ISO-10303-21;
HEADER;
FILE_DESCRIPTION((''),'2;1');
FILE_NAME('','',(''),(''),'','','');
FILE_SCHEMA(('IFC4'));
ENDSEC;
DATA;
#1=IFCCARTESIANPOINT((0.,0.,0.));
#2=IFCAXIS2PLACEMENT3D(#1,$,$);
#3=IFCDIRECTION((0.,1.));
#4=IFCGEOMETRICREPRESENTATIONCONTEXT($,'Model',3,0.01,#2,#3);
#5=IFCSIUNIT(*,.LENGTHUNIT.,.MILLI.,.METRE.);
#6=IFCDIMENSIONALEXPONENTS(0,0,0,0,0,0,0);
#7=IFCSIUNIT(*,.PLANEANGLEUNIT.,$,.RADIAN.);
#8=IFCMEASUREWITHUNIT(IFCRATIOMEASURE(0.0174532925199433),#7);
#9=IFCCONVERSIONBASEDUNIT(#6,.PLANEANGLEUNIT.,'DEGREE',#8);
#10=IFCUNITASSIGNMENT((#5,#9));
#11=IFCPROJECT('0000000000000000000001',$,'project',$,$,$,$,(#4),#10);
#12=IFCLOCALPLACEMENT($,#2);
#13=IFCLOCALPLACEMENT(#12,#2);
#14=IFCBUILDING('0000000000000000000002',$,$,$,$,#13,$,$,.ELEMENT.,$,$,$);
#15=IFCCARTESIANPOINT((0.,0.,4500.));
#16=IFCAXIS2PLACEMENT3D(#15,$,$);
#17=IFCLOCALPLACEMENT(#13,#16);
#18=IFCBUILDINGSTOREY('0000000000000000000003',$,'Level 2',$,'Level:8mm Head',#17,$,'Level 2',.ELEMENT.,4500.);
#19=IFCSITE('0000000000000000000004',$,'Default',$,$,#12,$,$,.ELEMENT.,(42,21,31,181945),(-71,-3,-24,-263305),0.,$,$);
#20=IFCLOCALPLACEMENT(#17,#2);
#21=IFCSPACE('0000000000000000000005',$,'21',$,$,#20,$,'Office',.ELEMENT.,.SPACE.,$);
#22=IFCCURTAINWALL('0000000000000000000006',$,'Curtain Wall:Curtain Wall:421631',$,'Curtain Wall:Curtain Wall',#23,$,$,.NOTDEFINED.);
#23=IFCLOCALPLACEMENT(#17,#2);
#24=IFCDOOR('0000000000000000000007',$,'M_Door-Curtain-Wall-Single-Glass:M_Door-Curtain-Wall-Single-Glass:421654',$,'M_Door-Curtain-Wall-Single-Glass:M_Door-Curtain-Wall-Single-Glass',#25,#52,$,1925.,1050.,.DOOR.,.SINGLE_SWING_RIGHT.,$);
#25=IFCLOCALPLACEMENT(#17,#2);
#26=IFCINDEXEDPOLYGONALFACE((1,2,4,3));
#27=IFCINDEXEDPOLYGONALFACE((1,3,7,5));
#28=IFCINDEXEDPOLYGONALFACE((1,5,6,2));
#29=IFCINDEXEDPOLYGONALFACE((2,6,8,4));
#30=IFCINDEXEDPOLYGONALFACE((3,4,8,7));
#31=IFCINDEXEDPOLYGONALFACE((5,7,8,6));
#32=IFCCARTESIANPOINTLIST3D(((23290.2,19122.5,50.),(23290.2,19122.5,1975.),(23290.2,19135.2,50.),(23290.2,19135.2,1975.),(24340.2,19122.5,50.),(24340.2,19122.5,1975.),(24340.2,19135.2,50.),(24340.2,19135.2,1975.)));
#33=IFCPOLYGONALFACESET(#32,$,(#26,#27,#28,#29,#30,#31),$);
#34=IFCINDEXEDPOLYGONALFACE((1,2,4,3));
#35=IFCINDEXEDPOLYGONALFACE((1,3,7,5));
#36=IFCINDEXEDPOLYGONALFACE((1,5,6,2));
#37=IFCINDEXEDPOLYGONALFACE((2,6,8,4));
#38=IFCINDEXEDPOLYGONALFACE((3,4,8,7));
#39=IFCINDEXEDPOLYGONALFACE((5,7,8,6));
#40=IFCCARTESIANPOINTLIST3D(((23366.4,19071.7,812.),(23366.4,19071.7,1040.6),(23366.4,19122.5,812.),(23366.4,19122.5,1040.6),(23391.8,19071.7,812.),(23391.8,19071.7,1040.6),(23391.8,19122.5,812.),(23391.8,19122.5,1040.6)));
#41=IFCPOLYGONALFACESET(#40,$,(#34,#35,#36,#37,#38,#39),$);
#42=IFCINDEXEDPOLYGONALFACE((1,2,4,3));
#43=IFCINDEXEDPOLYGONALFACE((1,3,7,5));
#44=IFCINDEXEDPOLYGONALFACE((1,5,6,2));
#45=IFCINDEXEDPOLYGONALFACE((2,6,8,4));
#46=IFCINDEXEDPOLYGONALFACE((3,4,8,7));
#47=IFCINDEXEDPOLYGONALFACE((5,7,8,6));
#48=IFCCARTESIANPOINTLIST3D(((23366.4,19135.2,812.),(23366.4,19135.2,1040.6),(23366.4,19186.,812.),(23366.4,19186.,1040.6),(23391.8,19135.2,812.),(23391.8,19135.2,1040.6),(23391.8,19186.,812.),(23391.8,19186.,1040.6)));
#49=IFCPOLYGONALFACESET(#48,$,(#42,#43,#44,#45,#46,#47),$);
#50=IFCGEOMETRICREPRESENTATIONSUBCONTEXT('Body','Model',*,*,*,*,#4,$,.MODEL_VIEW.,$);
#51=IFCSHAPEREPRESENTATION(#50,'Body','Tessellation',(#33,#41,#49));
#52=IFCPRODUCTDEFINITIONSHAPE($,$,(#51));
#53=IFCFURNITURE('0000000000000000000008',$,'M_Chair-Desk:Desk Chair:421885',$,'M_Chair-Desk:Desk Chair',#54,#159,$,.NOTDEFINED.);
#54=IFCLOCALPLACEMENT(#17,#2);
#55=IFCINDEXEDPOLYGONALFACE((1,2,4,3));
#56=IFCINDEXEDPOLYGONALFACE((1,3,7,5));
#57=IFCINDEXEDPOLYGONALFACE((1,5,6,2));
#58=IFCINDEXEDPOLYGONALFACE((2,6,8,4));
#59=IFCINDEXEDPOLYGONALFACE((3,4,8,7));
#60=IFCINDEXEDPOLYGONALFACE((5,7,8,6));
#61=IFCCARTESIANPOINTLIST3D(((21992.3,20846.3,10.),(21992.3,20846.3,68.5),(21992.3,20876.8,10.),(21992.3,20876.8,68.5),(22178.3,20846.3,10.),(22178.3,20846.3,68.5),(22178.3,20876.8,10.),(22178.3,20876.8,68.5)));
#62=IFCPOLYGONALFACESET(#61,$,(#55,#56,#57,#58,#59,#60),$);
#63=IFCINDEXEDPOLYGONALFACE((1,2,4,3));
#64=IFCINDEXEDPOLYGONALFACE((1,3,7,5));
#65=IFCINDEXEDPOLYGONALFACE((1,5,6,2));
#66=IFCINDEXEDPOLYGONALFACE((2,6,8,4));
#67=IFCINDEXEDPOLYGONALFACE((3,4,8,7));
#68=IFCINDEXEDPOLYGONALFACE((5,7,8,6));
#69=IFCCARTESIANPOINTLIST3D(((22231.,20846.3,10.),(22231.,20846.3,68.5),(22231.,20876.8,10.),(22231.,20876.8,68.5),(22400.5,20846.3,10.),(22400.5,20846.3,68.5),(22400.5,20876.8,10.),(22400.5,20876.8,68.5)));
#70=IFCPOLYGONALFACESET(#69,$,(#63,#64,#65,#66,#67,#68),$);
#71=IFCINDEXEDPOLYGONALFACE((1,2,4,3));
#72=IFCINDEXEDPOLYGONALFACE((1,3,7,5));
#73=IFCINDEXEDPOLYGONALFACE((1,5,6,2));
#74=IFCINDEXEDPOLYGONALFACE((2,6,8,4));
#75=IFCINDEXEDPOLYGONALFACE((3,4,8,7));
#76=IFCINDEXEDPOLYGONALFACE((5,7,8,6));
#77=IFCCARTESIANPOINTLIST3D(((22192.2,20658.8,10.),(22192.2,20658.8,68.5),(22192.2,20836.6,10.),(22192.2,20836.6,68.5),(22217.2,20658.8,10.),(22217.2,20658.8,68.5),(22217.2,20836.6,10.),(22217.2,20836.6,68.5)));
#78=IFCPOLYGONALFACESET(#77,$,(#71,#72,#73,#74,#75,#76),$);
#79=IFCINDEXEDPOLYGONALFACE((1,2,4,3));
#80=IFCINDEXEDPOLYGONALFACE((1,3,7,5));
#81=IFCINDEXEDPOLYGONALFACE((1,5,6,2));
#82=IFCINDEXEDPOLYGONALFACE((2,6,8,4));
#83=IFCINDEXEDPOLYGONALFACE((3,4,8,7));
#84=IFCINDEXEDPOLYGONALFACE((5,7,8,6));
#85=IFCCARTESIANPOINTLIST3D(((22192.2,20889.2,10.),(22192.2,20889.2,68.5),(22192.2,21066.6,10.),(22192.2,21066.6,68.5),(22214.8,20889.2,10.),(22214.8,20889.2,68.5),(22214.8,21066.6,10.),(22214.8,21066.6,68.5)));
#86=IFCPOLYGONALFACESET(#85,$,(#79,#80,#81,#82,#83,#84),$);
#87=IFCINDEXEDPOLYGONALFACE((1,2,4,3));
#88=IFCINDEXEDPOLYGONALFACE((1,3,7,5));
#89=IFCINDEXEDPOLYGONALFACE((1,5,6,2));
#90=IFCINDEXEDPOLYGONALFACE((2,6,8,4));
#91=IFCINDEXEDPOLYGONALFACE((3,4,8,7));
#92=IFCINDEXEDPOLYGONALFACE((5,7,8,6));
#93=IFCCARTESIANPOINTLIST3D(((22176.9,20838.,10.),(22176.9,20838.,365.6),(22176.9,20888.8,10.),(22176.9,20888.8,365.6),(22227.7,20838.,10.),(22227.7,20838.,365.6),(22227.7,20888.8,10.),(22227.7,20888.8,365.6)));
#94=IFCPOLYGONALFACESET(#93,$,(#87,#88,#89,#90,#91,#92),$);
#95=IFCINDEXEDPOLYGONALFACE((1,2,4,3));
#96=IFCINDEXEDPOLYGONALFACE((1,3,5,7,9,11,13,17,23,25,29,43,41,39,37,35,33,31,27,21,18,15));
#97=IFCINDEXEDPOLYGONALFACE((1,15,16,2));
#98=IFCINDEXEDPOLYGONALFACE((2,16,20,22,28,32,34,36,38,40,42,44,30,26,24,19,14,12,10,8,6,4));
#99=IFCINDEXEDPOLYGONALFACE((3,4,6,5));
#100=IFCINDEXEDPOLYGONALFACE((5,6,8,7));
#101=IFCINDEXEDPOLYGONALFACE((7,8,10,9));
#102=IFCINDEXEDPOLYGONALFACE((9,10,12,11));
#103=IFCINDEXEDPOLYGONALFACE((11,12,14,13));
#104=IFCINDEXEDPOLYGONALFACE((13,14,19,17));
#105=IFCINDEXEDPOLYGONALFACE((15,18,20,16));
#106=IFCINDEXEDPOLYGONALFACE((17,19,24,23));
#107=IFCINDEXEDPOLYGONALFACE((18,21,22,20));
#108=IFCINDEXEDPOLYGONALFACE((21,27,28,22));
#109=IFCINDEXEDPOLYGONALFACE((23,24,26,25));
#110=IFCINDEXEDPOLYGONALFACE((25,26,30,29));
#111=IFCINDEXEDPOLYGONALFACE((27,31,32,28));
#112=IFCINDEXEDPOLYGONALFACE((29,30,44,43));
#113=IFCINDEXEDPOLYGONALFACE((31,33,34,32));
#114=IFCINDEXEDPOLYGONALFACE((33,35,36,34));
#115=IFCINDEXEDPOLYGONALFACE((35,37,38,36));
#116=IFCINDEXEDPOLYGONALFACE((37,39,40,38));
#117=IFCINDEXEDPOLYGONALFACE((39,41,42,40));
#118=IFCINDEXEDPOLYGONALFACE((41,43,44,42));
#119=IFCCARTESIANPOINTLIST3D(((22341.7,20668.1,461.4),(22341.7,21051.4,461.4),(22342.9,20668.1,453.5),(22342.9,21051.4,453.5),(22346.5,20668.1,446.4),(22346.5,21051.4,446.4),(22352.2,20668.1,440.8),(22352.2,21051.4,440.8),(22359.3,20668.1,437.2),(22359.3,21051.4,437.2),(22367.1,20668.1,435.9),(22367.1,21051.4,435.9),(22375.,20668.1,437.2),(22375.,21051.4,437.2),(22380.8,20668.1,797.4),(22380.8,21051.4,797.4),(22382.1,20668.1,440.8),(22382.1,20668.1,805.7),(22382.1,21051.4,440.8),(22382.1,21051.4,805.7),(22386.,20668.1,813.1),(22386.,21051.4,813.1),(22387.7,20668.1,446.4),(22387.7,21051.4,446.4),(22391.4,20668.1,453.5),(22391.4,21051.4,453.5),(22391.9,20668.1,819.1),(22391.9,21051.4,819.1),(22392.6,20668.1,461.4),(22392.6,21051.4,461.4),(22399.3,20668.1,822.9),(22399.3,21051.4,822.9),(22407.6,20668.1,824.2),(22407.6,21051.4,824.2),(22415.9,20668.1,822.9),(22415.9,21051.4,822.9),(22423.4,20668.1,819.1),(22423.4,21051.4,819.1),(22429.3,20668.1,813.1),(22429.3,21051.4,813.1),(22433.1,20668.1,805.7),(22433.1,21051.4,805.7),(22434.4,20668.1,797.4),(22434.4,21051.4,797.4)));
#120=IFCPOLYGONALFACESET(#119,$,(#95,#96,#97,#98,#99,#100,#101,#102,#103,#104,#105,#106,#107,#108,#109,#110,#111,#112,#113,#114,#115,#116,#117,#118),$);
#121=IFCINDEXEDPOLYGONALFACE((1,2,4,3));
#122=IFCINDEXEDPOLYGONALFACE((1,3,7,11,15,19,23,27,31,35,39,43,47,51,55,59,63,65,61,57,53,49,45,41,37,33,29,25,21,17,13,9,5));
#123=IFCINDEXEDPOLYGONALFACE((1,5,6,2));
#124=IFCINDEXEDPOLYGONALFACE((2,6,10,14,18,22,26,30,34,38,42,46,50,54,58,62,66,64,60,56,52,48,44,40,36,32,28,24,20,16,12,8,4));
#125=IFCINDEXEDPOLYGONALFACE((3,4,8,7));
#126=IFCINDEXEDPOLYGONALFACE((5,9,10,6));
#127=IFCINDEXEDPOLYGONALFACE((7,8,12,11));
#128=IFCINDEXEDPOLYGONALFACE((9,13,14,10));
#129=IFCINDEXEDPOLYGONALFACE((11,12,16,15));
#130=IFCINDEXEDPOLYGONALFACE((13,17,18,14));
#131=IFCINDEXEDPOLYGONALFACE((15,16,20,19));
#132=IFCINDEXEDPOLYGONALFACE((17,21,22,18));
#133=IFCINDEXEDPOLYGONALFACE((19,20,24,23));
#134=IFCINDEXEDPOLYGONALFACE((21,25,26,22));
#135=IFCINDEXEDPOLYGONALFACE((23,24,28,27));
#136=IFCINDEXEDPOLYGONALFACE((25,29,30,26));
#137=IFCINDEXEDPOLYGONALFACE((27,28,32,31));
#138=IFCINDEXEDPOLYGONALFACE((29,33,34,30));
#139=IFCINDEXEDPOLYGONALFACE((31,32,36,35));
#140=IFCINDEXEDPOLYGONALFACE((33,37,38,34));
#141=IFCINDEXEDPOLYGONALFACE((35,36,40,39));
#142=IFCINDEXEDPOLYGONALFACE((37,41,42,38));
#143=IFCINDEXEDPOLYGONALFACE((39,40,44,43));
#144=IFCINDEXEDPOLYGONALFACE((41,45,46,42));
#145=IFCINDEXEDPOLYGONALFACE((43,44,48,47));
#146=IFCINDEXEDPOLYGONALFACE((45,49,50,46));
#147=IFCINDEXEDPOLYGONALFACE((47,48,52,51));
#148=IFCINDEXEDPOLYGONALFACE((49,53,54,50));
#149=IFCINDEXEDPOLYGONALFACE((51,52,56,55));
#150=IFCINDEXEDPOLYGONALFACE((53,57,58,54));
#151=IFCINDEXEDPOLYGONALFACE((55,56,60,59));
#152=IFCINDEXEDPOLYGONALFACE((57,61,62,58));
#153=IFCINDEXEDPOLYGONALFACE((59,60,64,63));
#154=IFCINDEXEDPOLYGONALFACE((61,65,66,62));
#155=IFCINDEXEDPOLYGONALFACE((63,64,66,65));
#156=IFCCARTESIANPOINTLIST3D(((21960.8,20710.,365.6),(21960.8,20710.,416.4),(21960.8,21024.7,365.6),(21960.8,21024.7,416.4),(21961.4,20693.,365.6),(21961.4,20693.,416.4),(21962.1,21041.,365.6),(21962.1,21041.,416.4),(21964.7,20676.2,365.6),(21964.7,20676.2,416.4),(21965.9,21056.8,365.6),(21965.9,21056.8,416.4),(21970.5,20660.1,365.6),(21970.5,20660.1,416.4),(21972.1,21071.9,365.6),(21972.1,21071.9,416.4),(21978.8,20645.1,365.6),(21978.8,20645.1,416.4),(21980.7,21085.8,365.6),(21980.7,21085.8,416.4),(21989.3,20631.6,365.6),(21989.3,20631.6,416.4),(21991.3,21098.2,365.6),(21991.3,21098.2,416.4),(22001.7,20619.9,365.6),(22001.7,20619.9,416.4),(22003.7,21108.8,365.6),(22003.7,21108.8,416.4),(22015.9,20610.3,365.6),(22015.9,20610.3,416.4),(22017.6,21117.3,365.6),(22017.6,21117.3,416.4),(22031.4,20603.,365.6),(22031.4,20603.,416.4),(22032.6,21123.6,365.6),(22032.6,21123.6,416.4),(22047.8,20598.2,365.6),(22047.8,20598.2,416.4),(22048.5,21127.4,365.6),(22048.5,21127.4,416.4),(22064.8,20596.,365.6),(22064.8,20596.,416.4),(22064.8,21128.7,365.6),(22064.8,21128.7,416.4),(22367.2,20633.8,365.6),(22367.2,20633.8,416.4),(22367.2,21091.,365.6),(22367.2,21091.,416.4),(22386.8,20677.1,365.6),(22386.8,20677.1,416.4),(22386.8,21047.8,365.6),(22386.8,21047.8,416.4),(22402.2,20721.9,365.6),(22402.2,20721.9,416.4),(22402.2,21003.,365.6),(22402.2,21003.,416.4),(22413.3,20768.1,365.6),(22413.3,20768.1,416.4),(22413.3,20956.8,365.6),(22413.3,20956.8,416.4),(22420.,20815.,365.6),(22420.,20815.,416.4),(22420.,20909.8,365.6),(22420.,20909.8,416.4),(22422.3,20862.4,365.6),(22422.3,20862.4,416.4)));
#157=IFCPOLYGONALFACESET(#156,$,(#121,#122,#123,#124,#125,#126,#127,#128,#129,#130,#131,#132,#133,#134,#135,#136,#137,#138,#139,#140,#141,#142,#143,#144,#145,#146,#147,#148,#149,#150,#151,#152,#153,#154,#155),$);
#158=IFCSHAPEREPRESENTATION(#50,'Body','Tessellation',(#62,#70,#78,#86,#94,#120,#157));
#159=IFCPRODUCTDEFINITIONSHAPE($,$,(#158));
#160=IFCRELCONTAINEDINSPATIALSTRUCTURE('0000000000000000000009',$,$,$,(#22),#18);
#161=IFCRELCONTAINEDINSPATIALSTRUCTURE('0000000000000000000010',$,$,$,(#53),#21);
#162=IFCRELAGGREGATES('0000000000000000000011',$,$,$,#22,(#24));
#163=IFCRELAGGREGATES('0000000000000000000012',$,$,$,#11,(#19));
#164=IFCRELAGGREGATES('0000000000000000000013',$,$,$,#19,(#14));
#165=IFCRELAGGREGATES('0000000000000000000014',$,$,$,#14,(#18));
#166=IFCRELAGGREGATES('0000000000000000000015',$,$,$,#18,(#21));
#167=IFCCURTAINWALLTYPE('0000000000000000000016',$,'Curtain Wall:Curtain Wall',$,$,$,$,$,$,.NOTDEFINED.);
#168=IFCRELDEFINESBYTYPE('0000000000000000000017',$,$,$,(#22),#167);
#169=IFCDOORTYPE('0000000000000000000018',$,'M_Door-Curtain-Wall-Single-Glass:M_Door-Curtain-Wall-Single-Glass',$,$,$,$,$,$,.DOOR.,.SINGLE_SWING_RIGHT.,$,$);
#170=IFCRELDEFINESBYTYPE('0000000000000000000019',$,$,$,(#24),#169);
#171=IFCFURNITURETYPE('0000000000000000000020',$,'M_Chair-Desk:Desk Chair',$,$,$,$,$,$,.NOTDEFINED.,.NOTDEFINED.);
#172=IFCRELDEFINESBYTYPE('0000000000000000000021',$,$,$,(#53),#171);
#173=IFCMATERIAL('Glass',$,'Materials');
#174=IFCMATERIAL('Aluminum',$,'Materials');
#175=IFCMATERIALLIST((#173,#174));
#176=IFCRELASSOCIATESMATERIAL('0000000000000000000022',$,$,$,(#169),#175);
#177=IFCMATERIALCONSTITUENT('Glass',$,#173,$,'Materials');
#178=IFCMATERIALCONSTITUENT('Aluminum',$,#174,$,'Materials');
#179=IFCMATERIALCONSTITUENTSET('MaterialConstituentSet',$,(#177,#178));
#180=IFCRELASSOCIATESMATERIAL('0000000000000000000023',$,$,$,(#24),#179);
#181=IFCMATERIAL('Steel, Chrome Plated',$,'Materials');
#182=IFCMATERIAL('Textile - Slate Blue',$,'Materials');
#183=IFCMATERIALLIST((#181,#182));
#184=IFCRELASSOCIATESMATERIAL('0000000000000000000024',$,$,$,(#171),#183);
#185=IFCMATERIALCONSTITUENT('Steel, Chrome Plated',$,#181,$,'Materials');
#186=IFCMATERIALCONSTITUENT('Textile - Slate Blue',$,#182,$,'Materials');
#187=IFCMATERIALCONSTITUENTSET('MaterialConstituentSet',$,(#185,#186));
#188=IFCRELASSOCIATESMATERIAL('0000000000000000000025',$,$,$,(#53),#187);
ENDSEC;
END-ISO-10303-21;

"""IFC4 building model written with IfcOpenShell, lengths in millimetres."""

from ifc_helpers import new_model, entity, si_unit, converted_unit, direction, frame, origin, place, context, subcontext, project, spatial, indexed_curve, outline, extrude, source, transform, mapped, material, material_list, constituent, constituent_set, type_object, type_shapes, element, aggregate, save


model = new_model("IFC4")

# Units and contexts
model_context = context("Model", 3, precision=0.01, world=origin(), true_north=direction((0.0, 1.0)))
body_context = subcontext(model_context, "Body", "Model", "MODEL_VIEW")
ifc_project = project(units=[si_unit("LENGTHUNIT", "METRE", prefix="MILLI"), converted_unit("PLANEANGLEUNIT", "DEGREE", entity("IfcRatioMeasure", 0.0174532925199433), si_unit("PLANEANGLEUNIT", "RADIAN"), dimensions=[0, 0, 0, 0, 0, 0, 0])], contexts=[model_context])

# Site, building, storey
site_placement = place(None, origin())
site = spatial("IfcSite", under=ifc_project, at=site_placement, Name="Default", CompositionType="ELEMENT", RefLatitude=(42, 21, 31, 181945), RefLongitude=(-71, -3, -24, -263305), RefElevation=0.0)
building_placement = place(site_placement, origin())
building = spatial("IfcBuilding", under=site, at=building_placement, CompositionType="ELEMENT")
storey_placement = place(building_placement, frame((0.0, 0.0, 4500.0)))
storey = spatial("IfcBuildingStorey", under=building, at=storey_placement, Name="Level 2", ObjectType="Level:8mm Head", LongName="Level 2", CompositionType="ELEMENT", Elevation=4500.0)

# Curtain wall
curtain_wall_type_1 = type_object("IfcCurtainWallType", Name="Curtain Wall:Curtain Wall", PredefinedType="NOTDEFINED")
curtain_wall_1_placement = place(storey_placement, frame((0.0, 0.0, -4500.0)))
curtain_wall_1 = element("IfcCurtainWall", 1, at=curtain_wall_1_placement, inside=storey, type_object=curtain_wall_type_1, Name="Curtain Wall:Curtain Wall:421631", ObjectType="Curtain Wall:Curtain Wall", PredefinedType="NOTDEFINED")

# Shared definitions
ifc_material_1 = material(Name="Glass", Category="Materials")

# Door
ifc_constituent_1 = constituent(ifc_material_1, Name="Glass", Category="Materials")
ifc_material_2 = material(Name="Aluminum", Category="Materials")
ifc_constituent_2 = constituent(ifc_material_2, Name="Aluminum", Category="Materials")
ifc_constituent_set_1 = constituent_set(constituents=[ifc_constituent_1, ifc_constituent_2], Name="MaterialConstituentSet")
ifc_material_list_1 = material_list([ifc_material_1, ifc_material_2])
door_type = type_object("IfcDoorType", Name="M_Door-Curtain-Wall-Single-Glass:M_Door-Curtain-Wall-Single-Glass", OperationType="SINGLE_SWING_RIGHT", PredefinedType="DOOR", material=ifc_material_list_1)
shared_shape_1 = source(origin(), body_context, "Body", "SweptSolid", [
    extrude(outline(indexed_curve([(-525.0, -6.4), (525.0, -6.4), (525.0, 6.4), (-525.0, 6.4), (-525.0, -6.4)], self_intersect=False)), frame((0.0, 44.5, 0.0), z_axis=(0.0, 0.0, 1.0), x_axis=(-1.0, 0.0, 0.0)), (0.0, 0.0, 1.0), 1925.0),
    extrude(outline(indexed_curve([(-25.4, -12.7), (25.4, -12.7), (25.4, 12.7), (-25.4, 12.7), (-25.4, -12.7)], self_intersect=False)), frame((-436.1, 12.7, 762.0), z_axis=(0.0, 0.0, 1.0), x_axis=(0.0, 1.0, 0.0)), (0.0, 0.0, 1.0), 228.6),
    extrude(outline(indexed_curve([(-25.4, -12.7), (25.4, -12.7), (25.4, 12.7), (-25.4, 12.7), (-25.4, -12.7)], self_intersect=False)), frame((-436.1, 76.2, 762.0), z_axis=(0.0, 0.0, 1.0), x_axis=(0.0, -1.0, 0.0)), (0.0, 0.0, 1.0), 228.6),
])
type_shapes(door_type, [shared_shape_1])
door_placement = place(curtain_wall_1_placement, frame((23815.2, 19084.4, 4550.0)))
door = element("IfcDoor", 2, at=door_placement, type_object=door_type, material=ifc_constituent_set_1, Name="M_Door-Curtain-Wall-Single-Glass:M_Door-Curtain-Wall-Single-Glass:421654", ObjectType="M_Door-Curtain-Wall-Single-Glass:M_Door-Curtain-Wall-Single-Glass", OperationType="SINGLE_SWING_RIGHT", OverallHeight=1925.0, OverallWidth=1050.0, PredefinedType="DOOR", context=body_context, shape_type="MappedRepresentation", body=[
    mapped(shared_shape_1, transform((0.0, 0.0, 0.0), scale=1.0)),
])
aggregate(curtain_wall_1, [door])

# Shared definitions
space_placement = place(storey_placement, origin())
space = spatial("IfcSpace", under=storey, at=space_placement, Name="21", LongName="Office", CompositionType="ELEMENT", PredefinedType="SPACE")

# Furniture
ifc_material_3 = material(Name="Steel, Chrome Plated", Category="Materials")
ifc_constituent_3 = constituent(ifc_material_3, Name="Steel, Chrome Plated", Category="Materials")
ifc_material_4 = material(Name="Textile - Slate Blue", Category="Materials")
ifc_constituent_4 = constituent(ifc_material_4, Name="Textile - Slate Blue", Category="Materials")
ifc_constituent_set_2 = constituent_set(constituents=[ifc_constituent_3, ifc_constituent_4], Name="MaterialConstituentSet")
ifc_material_list_2 = material_list([ifc_material_3, ifc_material_4])
furniture_type = type_object("IfcFurnitureType", Name="M_Chair-Desk:Desk Chair", AssemblyPlace="NOTDEFINED", PredefinedType="NOTDEFINED", material=ifc_material_list_2)
shared_shape_2 = source(origin(), body_context, "Body", "SweptSolid", [
    extrude(outline(indexed_curve([(-15.2, -93.0), (15.2, -93.0), (15.2, 93.0), (-15.2, 93.0), (-15.2, -93.0)], self_intersect=False)), frame((-0.9, 281.9, 0.0)), (0.0, 0.0, 1.0), 58.5),
    extrude(outline(indexed_curve([(-15.2, -84.7), (15.2, -84.7), (15.2, 84.7), (-15.2, 84.7), (-15.2, -84.7)], self_intersect=False)), frame((-0.9, 51.5, 0.0), z_axis=(0.0, 0.0, 1.0), x_axis=(-1.0, 0.0, 0.0)), (0.0, 0.0, 1.0), 58.5),
    extrude(outline(indexed_curve([(-12.5, -88.9), (12.5, -88.9), (12.5, 88.9), (-12.5, 88.9), (-12.5, -88.9)], self_intersect=False)), frame((-114.8, 162.5, 0.0), z_axis=(0.0, 0.0, 1.0), x_axis=(0.0, -1.0, 0.0)), (0.0, 0.0, 1.0), 58.5),
    extrude(outline(indexed_curve([(-88.7, -11.3), (88.7, -11.3), (88.7, 11.3), (-88.7, 11.3), (-88.7, -11.3)], self_intersect=False)), frame((115.5, 163.7, 0.0), z_axis=(0.0, 0.0, 1.0), x_axis=(-1.0, 0.0, 0.0)), (0.0, 0.0, 1.0), 58.5),
    extrude(outline(indexed_curve([(-25.4, -25.4), (25.4, -25.4), (25.4, 25.4), (-25.4, 25.4), (-25.4, -25.4)], self_intersect=False)), frame((0.9, 164.9, 0.0), z_axis=(0.0, 0.0, 1.0), x_axis=(-1.0, 0.0, 0.0)), (0.0, 0.0, 1.0), 355.6),
    extrude(outline(indexed_curve([(6.5, 168.0), (5.2, 176.3), (1.4, 183.8), (-4.5, 189.7), (-12.0, 193.5), (-20.2, 194.8), (-28.5, 193.5), (-36.0, 189.7), (-41.9, 183.8), (-45.7, 176.3), (-47.0, 168.0), (-5.2, -168.0), (-4.0, -175.9), (-0.4, -183.0), (5.3, -188.6), (12.4, -192.2), (20.2, -193.5), (28.1, -192.2), (35.2, -188.6), (40.9, -183.0), (44.5, -175.9), (45.7, -168.0), (6.5, 168.0)], self_intersect=False)), frame((-194.4, -20.2, 619.4), z_axis=(1.0, 0.0, 0.0), x_axis=(0.0, 1.0, 0.0)), (0.0, 0.0, 1.0), 383.3),
    extrude(outline(indexed_curve([(-98.9, -257.7), (205.9, -257.7), (230.7, -217.3), (251.6, -174.7), (268.3, -130.3), (280.8, -84.5), (288.9, -37.7), (292.6, 9.6), (291.7, 57.0), (286.4, 104.2), (276.7, 150.6), (262.6, 195.9), (-32.8, 270.8), (-49.1, 271.5), (-65.3, 269.7), (-81.1, 265.4), (-95.9, 258.6), (-109.5, 249.7), (-121.6, 238.7), (-131.8, 225.9), (-139.8, 211.7), (-145.6, 196.5), (-148.9, 180.5), (-187.9, -131.7), (-189.4, -148.8), (-188.3, -165.8), (-184.5, -182.5), (-178.1, -198.4), (-169.4, -213.1), (-158.5, -226.2), (-145.6, -237.5), (-131.2, -246.7), (-115.5, -253.5), (-98.9, -257.7)], self_intersect=False)), frame((1.6, 236.3, 355.6), z_axis=(0.0, 0.0, 1.0), x_axis=(0.124035, -0.992278, 0.0)), (0.0, 0.0, 1.0), 50.8),
])
type_shapes(furniture_type, [shared_shape_2])
furniture_1_placement = place(space_placement, frame((22367.2, 20862.4, 10.0), z_axis=(0.0, 0.0, 1.0), x_axis=(0.0, 1.0, 0.0)))
element("IfcFurniture", 3, at=furniture_1_placement, inside=space, type_object=furniture_type, material=ifc_constituent_set_2, Name="M_Chair-Desk:Desk Chair:421885", ObjectType="M_Chair-Desk:Desk Chair", PredefinedType="NOTDEFINED", context=body_context, shape_type="MappedRepresentation", body=[
    mapped(shared_shape_2, transform((0.0, 0.0, 0.0), scale=1.0)),
])

save(model, "model.ifc")
